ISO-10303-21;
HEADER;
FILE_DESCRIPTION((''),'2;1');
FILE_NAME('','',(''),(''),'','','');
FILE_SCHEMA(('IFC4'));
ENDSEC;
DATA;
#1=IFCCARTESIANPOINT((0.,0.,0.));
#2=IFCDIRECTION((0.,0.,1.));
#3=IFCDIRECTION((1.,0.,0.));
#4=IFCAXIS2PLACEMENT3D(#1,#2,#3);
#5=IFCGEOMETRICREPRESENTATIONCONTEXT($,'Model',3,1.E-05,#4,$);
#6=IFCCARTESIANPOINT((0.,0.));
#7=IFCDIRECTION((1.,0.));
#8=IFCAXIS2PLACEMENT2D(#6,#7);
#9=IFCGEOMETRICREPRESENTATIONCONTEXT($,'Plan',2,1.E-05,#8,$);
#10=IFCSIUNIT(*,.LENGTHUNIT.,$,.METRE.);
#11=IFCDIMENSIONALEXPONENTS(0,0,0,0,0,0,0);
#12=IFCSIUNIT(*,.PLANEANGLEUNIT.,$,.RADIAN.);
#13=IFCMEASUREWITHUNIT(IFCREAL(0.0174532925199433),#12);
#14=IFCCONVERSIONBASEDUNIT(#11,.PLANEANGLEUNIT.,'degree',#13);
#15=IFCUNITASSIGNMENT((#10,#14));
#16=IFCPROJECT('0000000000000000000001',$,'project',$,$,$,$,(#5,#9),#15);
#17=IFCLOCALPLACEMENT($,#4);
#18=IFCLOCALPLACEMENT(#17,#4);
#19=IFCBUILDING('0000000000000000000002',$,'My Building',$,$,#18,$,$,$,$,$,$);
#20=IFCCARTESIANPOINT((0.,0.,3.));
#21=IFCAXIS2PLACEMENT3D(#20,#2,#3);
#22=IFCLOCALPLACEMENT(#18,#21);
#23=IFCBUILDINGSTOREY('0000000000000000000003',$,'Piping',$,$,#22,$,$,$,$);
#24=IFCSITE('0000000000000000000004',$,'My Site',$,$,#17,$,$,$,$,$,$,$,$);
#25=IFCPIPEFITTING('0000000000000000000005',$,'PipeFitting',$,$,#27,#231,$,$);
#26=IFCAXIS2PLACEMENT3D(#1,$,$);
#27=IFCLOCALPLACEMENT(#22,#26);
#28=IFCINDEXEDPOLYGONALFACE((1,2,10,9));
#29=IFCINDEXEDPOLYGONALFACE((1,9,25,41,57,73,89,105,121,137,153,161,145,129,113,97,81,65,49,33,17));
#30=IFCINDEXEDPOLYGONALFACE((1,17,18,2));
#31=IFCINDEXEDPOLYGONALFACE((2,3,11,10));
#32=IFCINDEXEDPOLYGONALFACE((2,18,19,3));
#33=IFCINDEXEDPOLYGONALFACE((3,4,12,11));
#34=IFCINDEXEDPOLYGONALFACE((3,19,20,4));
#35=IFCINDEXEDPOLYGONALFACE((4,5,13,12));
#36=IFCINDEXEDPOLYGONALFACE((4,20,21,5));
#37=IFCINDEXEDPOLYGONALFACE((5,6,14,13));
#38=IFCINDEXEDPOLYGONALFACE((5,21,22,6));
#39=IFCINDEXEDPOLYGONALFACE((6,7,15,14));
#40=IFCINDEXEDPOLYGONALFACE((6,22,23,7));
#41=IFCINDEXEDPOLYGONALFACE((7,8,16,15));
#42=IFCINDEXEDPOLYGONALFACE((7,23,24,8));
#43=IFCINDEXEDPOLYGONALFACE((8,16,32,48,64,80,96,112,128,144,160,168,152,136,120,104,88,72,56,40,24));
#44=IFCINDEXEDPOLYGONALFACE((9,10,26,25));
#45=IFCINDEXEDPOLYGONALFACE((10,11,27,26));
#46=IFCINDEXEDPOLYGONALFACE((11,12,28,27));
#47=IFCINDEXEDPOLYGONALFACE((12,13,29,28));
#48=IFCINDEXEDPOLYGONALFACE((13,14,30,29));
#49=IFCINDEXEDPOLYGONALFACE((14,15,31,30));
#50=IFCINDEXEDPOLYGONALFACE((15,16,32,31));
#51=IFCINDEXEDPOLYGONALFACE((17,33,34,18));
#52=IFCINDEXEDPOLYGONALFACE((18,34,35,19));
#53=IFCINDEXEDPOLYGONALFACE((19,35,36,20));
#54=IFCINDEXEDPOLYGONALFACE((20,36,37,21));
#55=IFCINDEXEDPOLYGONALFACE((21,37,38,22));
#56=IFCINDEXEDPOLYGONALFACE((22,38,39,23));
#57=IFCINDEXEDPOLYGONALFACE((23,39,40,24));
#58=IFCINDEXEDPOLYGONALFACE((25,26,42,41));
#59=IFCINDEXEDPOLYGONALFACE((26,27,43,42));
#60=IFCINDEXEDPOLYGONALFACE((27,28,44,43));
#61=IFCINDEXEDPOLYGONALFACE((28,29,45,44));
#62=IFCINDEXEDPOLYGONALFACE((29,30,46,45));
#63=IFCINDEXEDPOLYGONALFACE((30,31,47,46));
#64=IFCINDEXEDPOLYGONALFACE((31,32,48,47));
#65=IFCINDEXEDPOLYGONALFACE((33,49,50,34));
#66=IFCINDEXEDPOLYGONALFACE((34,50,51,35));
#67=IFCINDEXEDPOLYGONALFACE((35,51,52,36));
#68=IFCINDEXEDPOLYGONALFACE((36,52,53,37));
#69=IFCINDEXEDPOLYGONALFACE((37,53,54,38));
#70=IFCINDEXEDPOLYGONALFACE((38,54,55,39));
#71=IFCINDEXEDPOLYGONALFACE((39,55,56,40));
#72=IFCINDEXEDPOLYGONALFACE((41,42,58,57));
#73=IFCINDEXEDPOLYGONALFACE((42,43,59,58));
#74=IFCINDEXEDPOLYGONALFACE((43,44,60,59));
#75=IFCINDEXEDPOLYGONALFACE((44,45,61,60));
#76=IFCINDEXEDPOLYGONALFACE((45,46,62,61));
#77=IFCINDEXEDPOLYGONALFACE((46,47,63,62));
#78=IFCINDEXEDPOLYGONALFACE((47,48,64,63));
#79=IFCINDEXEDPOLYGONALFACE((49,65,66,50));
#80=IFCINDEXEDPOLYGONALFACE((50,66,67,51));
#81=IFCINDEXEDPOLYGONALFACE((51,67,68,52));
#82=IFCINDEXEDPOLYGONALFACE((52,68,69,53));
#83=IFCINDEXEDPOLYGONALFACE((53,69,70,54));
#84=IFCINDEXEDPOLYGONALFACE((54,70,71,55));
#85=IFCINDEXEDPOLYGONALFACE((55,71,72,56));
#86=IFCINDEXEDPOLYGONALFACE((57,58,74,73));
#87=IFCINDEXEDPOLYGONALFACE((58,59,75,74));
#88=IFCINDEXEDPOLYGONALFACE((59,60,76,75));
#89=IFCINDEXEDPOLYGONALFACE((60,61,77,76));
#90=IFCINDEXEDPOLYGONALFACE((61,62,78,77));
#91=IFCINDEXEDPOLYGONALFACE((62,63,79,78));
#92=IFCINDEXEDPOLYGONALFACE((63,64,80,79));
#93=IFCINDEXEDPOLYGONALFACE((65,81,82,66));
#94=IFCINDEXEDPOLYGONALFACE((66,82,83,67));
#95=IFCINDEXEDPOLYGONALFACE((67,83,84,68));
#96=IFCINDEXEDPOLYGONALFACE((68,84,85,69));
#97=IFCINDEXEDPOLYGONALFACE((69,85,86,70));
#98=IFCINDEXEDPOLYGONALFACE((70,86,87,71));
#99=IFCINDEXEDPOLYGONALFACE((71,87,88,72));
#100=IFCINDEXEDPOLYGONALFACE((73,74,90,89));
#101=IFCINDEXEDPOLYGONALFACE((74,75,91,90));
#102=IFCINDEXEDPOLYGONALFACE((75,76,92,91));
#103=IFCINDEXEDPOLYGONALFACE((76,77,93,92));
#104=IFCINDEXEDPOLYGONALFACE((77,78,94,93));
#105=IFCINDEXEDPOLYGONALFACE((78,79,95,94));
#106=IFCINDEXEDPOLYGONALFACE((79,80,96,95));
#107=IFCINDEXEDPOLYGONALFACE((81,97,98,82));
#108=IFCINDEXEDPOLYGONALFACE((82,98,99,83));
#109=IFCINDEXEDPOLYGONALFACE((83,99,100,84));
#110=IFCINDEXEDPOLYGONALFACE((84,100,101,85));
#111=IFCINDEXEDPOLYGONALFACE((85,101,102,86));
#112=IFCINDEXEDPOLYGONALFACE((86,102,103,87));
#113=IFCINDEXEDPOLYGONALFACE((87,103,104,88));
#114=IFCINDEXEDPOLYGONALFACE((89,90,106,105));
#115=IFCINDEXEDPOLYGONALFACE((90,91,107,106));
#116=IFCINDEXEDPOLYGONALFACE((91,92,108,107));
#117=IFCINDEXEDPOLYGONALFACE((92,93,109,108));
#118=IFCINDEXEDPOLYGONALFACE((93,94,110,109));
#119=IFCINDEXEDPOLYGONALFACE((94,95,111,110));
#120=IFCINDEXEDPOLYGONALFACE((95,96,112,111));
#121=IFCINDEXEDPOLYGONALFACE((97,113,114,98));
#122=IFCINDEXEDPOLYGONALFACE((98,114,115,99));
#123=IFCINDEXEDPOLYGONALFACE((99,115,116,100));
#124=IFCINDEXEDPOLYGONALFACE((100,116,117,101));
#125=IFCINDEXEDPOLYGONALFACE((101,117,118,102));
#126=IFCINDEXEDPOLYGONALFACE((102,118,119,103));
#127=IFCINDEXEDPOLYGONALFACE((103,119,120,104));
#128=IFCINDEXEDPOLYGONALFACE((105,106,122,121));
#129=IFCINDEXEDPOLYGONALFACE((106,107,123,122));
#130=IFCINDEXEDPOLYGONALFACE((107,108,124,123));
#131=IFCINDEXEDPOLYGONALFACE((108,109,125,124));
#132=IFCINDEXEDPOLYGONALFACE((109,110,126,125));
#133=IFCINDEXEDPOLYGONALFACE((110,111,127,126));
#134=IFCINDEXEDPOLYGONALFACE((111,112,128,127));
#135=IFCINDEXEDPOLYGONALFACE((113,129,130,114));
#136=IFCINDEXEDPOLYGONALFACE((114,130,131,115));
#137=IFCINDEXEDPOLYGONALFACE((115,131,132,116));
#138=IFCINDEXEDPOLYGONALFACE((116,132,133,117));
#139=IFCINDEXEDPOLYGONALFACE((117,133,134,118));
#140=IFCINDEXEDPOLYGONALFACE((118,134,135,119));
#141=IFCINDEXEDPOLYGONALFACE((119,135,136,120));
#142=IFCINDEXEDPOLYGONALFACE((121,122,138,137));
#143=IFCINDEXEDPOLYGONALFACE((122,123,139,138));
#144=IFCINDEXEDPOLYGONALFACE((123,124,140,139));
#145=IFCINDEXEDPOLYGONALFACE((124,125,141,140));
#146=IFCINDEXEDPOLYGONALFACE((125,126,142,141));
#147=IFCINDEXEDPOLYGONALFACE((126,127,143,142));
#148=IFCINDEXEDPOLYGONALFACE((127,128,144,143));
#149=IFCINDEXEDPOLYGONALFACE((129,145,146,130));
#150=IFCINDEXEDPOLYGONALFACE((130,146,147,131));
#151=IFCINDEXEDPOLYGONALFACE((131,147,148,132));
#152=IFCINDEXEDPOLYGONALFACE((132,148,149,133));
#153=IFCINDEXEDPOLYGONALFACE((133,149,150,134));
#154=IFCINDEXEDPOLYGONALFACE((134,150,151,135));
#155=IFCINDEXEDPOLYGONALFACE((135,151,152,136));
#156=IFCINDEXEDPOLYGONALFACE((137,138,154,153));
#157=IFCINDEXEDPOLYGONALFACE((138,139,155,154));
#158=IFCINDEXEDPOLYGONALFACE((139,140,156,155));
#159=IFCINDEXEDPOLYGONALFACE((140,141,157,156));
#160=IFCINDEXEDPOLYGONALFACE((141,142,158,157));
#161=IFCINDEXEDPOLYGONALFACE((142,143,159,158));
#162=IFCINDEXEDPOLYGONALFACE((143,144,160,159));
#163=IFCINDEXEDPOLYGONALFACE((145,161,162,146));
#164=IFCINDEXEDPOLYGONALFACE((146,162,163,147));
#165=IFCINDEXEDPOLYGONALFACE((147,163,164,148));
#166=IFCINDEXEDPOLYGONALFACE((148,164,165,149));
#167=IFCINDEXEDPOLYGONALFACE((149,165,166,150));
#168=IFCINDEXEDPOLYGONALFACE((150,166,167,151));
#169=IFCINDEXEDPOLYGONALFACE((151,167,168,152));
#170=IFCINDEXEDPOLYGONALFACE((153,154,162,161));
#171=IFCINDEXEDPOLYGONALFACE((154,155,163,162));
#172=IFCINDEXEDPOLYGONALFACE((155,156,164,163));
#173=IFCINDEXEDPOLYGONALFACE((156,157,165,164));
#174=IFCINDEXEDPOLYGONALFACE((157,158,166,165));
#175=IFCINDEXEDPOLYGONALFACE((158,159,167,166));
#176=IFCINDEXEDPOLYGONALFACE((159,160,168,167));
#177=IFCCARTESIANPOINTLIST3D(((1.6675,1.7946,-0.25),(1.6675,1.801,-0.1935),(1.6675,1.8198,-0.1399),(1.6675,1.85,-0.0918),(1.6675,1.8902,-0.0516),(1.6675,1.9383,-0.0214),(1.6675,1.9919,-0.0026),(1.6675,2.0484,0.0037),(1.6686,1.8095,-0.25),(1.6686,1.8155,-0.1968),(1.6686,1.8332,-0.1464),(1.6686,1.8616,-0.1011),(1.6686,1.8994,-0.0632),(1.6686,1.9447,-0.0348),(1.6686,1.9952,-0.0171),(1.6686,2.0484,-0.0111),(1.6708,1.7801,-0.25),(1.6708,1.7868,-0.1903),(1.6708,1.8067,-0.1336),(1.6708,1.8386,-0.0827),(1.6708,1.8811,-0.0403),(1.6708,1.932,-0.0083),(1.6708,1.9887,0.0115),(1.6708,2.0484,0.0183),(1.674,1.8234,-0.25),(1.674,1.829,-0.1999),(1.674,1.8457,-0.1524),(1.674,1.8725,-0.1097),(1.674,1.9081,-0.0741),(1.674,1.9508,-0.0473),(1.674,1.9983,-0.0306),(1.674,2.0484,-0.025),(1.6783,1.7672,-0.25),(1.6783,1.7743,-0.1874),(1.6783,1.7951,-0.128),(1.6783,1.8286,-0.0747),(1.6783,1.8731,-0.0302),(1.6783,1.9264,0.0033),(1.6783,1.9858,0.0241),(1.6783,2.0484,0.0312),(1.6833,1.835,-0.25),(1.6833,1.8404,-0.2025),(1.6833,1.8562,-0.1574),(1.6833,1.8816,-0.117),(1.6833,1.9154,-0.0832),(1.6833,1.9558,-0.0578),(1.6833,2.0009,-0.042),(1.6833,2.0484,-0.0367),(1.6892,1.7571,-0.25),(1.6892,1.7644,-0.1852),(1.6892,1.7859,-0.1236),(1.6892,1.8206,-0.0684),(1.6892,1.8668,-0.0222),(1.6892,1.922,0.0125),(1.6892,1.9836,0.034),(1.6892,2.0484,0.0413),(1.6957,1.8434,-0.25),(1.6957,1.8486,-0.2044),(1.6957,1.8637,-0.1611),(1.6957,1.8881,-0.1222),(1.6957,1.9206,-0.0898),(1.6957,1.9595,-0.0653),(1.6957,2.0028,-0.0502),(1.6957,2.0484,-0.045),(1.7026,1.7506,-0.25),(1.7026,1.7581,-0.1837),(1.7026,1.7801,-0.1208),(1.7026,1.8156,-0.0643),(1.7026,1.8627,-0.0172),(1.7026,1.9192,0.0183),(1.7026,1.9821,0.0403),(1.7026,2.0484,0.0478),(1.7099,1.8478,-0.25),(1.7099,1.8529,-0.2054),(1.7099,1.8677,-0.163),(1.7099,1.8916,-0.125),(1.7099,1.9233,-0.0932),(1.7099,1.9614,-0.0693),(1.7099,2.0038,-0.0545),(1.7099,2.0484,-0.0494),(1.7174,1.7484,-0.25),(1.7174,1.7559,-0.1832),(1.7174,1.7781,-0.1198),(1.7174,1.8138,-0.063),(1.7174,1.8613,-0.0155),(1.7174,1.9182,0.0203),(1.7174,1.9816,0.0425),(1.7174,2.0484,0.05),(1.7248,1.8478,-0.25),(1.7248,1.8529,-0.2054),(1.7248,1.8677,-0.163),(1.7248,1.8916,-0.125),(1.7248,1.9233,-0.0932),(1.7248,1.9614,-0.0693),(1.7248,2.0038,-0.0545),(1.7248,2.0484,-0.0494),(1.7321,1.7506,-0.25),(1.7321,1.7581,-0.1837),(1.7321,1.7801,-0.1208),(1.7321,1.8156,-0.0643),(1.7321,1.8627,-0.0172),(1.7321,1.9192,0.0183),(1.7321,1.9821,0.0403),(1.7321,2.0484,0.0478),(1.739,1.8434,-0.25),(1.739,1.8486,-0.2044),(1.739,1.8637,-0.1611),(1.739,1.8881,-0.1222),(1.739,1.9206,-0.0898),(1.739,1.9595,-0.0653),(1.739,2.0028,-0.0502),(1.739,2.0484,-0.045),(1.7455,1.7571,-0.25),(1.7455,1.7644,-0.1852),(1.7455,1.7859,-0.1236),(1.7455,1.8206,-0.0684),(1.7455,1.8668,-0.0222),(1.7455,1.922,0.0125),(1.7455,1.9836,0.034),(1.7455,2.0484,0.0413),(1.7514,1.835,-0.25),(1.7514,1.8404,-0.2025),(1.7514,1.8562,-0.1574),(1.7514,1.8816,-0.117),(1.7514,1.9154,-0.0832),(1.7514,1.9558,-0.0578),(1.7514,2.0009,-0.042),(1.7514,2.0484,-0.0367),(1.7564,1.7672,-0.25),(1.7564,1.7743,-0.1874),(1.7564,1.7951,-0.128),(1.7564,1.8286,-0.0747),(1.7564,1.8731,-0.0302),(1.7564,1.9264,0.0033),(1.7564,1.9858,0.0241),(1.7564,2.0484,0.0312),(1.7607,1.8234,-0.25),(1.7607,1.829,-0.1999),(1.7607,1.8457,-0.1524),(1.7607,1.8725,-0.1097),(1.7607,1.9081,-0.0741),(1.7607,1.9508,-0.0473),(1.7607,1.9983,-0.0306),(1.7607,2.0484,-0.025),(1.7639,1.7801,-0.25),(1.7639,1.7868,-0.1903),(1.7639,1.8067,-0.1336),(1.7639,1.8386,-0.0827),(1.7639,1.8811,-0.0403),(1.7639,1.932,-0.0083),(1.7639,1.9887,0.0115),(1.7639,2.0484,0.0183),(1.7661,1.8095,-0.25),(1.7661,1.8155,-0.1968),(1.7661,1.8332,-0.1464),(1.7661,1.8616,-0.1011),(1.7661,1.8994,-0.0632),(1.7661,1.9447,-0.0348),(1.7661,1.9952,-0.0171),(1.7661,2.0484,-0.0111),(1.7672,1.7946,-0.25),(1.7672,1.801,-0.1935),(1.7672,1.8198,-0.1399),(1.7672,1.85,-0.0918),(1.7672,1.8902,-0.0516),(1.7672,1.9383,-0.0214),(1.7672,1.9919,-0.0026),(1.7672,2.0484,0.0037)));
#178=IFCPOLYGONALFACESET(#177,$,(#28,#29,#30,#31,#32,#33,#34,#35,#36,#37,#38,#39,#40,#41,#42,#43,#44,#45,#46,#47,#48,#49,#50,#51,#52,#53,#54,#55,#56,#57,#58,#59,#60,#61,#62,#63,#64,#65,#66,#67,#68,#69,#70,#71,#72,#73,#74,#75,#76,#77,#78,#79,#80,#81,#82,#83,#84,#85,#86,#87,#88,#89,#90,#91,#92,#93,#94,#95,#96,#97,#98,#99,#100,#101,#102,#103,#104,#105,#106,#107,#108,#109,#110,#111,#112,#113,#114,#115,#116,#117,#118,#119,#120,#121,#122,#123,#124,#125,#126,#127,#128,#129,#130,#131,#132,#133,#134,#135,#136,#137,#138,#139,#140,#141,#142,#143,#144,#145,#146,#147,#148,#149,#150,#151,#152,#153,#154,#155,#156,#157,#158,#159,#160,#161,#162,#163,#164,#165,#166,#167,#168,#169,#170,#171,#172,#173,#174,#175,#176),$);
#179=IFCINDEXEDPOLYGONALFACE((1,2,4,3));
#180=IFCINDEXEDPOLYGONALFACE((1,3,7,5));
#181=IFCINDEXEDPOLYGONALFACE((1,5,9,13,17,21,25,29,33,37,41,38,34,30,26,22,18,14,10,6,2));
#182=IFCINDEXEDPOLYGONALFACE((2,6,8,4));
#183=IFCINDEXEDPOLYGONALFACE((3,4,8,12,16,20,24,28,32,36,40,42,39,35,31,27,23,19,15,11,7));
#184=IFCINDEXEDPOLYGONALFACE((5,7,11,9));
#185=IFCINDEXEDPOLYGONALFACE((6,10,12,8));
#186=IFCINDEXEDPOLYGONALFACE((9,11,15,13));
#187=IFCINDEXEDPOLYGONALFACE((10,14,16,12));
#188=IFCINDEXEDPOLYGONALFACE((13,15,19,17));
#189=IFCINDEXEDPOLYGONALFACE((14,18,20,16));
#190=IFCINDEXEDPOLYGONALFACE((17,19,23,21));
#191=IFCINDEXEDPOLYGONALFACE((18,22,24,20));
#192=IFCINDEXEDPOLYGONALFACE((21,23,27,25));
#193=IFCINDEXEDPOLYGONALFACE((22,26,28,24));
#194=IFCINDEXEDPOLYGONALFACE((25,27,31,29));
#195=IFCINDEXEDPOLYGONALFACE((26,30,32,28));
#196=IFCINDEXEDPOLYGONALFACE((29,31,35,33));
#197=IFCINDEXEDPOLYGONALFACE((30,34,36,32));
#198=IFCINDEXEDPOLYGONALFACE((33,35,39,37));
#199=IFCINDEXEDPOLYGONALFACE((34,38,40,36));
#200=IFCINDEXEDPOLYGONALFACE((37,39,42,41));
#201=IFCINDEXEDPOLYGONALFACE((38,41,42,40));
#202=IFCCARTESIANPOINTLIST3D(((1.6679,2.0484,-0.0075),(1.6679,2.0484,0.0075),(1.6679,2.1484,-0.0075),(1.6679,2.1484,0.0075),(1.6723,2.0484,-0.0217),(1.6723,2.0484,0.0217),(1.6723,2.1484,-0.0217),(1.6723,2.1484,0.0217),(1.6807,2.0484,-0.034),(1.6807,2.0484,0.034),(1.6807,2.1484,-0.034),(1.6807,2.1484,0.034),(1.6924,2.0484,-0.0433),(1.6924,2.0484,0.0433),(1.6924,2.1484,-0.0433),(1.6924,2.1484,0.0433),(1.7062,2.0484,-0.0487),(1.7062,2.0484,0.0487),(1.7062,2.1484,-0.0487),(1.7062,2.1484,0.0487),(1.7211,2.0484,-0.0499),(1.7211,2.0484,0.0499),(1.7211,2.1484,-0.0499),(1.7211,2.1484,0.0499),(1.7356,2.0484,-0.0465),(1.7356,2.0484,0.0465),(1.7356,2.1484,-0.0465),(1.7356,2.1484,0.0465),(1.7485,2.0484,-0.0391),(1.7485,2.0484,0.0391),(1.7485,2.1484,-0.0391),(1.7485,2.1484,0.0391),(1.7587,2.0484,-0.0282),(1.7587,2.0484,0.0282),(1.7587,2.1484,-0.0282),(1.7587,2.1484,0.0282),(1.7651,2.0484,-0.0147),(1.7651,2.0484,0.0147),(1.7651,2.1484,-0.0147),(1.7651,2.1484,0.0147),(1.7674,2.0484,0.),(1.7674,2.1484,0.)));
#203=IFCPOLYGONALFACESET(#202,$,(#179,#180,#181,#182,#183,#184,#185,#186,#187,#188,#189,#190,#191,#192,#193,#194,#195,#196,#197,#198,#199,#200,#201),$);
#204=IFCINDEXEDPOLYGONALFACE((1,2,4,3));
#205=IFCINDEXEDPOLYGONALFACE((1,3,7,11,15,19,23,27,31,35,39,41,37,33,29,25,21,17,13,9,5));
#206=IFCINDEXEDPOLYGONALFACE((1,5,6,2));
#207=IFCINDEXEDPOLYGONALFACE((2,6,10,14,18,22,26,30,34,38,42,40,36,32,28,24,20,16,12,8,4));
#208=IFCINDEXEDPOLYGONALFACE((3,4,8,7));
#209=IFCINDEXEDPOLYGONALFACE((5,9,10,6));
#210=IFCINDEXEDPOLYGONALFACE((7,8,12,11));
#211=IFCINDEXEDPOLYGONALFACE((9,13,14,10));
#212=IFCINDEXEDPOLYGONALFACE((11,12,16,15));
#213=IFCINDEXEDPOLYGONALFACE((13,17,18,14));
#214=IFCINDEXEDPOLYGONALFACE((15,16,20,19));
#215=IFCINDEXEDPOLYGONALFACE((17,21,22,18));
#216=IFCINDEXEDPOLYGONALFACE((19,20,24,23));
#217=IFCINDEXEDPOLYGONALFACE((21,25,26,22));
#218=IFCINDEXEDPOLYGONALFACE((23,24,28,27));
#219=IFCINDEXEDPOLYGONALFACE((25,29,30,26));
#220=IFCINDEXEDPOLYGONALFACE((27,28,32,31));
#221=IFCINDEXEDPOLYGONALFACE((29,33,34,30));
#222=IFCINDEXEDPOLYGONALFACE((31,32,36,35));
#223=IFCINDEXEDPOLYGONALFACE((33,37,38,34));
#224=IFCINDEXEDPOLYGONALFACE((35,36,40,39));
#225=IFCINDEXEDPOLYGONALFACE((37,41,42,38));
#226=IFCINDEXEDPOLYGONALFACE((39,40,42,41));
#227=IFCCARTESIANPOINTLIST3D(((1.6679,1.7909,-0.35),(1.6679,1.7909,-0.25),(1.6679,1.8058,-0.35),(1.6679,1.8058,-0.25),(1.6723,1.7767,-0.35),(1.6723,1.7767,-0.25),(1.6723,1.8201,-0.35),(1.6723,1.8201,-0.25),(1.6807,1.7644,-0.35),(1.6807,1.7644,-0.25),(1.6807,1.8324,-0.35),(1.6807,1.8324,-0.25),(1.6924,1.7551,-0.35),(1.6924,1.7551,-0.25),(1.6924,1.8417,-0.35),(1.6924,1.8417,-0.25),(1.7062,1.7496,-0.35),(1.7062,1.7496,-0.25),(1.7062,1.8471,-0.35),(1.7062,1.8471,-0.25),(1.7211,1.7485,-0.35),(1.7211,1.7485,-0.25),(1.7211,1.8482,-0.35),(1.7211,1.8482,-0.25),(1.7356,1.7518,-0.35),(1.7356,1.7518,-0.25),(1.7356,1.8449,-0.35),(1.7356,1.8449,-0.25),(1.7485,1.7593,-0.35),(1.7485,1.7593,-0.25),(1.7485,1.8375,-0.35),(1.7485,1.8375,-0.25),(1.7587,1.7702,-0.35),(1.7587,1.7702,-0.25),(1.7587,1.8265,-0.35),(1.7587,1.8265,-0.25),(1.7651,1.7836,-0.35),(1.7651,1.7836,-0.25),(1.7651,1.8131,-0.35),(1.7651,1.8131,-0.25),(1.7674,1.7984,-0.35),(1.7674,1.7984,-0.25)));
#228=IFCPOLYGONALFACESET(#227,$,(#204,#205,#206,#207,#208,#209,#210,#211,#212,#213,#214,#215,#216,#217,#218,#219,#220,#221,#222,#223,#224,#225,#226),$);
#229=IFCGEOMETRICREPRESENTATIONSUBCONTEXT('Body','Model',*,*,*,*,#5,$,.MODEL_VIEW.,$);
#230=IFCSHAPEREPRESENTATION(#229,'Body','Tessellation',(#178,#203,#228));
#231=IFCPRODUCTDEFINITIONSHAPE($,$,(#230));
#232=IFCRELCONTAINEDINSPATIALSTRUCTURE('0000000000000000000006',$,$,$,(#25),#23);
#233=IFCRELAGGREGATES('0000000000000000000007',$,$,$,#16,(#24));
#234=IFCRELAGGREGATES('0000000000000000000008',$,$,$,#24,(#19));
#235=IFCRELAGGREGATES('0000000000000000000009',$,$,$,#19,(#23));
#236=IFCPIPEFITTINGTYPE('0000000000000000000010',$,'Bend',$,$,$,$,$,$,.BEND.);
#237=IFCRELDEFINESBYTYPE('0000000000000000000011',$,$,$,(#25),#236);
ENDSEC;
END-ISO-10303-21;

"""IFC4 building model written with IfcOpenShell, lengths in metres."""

from ifc_helpers import new_model, entity, si_unit, converted_unit, frame, origin_with_axes, origin_2d_with_axis, place, context, subcontext, project, spatial, line, indexed_curve, circle, outline, extrude, source, transform, mapped, type_object, type_shapes, element, save


model = new_model("IFC4")

# Units and contexts
model_context = context("Model", 3, precision=1e-05, world=origin_with_axes())
plan_context = context("Plan", 2, precision=1e-05, world=origin_2d_with_axis())
body_context = subcontext(model_context, "Body", "Model", "MODEL_VIEW")
ifc_project = project(units=[si_unit("LENGTHUNIT", "METRE"), converted_unit("PLANEANGLEUNIT", "degree", entity("IfcReal", 0.0174532925199433), si_unit("PLANEANGLEUNIT", "RADIAN"), dimensions=[0, 0, 0, 0, 0, 0, 0])], contexts=[model_context, plan_context])

# Site, building, storey
site_placement = place(None, origin_with_axes())
site = spatial("IfcSite", under=ifc_project, at=site_placement, Name="My Site")
building_placement = place(site_placement, origin_with_axes())
building = spatial("IfcBuilding", under=site, at=building_placement, Name="My Building")
storey_placement = place(building_placement, frame((0.0, 0.0, 3.0), z_axis=(0.0, 0.0, 1.0), x_axis=(1.0, 0.0, 0.0)))
storey = spatial("IfcBuildingStorey", under=building, at=storey_placement, Name="Piping")

# Pipe fitting, opening
pipe_fitting_type = type_object("IfcPipeFittingType", Name="Bend", PredefinedType="BEND")
shared_shape = source(origin_with_axes(), body_context, "Body", "SolidModel", [
    entity("IfcSweptDiskSolid", entity("IfcIndexedPolyCurve", entity("IfcCartesianPointList3D", [[0.0, 0.0, 0.1], [0.0, -0.0732, 0.2768], [0.0, -0.25, 0.35]]), [entity("IfcArcIndex", [1, 2, 3])]), 0.05),
    extrude(circle(Radius=0.05), origin_with_axes(), (0.0, 0.0, 1.0), 0.1),
    extrude(circle(Radius=0.05), frame((0.0, -0.25, 0.35), z_axis=(0.0, -1.0, 0.0), x_axis=(1.0, 0.0, 0.0)), (0.0, 0.0, 1.0), 0.1),
])
type_shapes(pipe_fitting_type, [shared_shape])
pipe_fitting_1_placement = place(storey_placement, frame((1.7174, 2.1484, 0.0), z_axis=(0.0, -1.0, 0.0), x_axis=(1.0, 0.0, 0.0)))
pipe_fitting_1 = element("IfcPipeFitting", 1, at=pipe_fitting_1_placement, inside=storey, type_object=pipe_fitting_type, Name="PipeFitting", context=body_context, shape_type="MappedRepresentation", body=[
    mapped(shared_shape, transform((0.0, 0.0, 0.0), x_axis=(1.0, 0.0, 0.0), y_axis=(0.0, 1.0, 0.0), z_axis=(0.0, 0.0, 1.0), scale=1.0)),
])
opening_1_placement = place(pipe_fitting_1_placement, frame((-1.7174, -3.0, 2.1484), z_axis=(0.0, 1.0, 0.0), x_axis=(1.0, 0.0, 0.0)))
element("IfcOpeningElement", 2, at=opening_1_placement, cuts=pipe_fitting_1, PredefinedType="OPENING", context=body_context, shape_type="SweptSolid", body=[
    extrude(outline(indexed_curve([(0.0, 0.0), (0.5, 0.0), (0.5, 0.5), (0.0, 0.5)], segments=[line(1, 2, 3, 4, 1)])), origin_with_axes(), (0.0, 0.0, 1.0), 0.5),
])

save(model, "model.ifc")
